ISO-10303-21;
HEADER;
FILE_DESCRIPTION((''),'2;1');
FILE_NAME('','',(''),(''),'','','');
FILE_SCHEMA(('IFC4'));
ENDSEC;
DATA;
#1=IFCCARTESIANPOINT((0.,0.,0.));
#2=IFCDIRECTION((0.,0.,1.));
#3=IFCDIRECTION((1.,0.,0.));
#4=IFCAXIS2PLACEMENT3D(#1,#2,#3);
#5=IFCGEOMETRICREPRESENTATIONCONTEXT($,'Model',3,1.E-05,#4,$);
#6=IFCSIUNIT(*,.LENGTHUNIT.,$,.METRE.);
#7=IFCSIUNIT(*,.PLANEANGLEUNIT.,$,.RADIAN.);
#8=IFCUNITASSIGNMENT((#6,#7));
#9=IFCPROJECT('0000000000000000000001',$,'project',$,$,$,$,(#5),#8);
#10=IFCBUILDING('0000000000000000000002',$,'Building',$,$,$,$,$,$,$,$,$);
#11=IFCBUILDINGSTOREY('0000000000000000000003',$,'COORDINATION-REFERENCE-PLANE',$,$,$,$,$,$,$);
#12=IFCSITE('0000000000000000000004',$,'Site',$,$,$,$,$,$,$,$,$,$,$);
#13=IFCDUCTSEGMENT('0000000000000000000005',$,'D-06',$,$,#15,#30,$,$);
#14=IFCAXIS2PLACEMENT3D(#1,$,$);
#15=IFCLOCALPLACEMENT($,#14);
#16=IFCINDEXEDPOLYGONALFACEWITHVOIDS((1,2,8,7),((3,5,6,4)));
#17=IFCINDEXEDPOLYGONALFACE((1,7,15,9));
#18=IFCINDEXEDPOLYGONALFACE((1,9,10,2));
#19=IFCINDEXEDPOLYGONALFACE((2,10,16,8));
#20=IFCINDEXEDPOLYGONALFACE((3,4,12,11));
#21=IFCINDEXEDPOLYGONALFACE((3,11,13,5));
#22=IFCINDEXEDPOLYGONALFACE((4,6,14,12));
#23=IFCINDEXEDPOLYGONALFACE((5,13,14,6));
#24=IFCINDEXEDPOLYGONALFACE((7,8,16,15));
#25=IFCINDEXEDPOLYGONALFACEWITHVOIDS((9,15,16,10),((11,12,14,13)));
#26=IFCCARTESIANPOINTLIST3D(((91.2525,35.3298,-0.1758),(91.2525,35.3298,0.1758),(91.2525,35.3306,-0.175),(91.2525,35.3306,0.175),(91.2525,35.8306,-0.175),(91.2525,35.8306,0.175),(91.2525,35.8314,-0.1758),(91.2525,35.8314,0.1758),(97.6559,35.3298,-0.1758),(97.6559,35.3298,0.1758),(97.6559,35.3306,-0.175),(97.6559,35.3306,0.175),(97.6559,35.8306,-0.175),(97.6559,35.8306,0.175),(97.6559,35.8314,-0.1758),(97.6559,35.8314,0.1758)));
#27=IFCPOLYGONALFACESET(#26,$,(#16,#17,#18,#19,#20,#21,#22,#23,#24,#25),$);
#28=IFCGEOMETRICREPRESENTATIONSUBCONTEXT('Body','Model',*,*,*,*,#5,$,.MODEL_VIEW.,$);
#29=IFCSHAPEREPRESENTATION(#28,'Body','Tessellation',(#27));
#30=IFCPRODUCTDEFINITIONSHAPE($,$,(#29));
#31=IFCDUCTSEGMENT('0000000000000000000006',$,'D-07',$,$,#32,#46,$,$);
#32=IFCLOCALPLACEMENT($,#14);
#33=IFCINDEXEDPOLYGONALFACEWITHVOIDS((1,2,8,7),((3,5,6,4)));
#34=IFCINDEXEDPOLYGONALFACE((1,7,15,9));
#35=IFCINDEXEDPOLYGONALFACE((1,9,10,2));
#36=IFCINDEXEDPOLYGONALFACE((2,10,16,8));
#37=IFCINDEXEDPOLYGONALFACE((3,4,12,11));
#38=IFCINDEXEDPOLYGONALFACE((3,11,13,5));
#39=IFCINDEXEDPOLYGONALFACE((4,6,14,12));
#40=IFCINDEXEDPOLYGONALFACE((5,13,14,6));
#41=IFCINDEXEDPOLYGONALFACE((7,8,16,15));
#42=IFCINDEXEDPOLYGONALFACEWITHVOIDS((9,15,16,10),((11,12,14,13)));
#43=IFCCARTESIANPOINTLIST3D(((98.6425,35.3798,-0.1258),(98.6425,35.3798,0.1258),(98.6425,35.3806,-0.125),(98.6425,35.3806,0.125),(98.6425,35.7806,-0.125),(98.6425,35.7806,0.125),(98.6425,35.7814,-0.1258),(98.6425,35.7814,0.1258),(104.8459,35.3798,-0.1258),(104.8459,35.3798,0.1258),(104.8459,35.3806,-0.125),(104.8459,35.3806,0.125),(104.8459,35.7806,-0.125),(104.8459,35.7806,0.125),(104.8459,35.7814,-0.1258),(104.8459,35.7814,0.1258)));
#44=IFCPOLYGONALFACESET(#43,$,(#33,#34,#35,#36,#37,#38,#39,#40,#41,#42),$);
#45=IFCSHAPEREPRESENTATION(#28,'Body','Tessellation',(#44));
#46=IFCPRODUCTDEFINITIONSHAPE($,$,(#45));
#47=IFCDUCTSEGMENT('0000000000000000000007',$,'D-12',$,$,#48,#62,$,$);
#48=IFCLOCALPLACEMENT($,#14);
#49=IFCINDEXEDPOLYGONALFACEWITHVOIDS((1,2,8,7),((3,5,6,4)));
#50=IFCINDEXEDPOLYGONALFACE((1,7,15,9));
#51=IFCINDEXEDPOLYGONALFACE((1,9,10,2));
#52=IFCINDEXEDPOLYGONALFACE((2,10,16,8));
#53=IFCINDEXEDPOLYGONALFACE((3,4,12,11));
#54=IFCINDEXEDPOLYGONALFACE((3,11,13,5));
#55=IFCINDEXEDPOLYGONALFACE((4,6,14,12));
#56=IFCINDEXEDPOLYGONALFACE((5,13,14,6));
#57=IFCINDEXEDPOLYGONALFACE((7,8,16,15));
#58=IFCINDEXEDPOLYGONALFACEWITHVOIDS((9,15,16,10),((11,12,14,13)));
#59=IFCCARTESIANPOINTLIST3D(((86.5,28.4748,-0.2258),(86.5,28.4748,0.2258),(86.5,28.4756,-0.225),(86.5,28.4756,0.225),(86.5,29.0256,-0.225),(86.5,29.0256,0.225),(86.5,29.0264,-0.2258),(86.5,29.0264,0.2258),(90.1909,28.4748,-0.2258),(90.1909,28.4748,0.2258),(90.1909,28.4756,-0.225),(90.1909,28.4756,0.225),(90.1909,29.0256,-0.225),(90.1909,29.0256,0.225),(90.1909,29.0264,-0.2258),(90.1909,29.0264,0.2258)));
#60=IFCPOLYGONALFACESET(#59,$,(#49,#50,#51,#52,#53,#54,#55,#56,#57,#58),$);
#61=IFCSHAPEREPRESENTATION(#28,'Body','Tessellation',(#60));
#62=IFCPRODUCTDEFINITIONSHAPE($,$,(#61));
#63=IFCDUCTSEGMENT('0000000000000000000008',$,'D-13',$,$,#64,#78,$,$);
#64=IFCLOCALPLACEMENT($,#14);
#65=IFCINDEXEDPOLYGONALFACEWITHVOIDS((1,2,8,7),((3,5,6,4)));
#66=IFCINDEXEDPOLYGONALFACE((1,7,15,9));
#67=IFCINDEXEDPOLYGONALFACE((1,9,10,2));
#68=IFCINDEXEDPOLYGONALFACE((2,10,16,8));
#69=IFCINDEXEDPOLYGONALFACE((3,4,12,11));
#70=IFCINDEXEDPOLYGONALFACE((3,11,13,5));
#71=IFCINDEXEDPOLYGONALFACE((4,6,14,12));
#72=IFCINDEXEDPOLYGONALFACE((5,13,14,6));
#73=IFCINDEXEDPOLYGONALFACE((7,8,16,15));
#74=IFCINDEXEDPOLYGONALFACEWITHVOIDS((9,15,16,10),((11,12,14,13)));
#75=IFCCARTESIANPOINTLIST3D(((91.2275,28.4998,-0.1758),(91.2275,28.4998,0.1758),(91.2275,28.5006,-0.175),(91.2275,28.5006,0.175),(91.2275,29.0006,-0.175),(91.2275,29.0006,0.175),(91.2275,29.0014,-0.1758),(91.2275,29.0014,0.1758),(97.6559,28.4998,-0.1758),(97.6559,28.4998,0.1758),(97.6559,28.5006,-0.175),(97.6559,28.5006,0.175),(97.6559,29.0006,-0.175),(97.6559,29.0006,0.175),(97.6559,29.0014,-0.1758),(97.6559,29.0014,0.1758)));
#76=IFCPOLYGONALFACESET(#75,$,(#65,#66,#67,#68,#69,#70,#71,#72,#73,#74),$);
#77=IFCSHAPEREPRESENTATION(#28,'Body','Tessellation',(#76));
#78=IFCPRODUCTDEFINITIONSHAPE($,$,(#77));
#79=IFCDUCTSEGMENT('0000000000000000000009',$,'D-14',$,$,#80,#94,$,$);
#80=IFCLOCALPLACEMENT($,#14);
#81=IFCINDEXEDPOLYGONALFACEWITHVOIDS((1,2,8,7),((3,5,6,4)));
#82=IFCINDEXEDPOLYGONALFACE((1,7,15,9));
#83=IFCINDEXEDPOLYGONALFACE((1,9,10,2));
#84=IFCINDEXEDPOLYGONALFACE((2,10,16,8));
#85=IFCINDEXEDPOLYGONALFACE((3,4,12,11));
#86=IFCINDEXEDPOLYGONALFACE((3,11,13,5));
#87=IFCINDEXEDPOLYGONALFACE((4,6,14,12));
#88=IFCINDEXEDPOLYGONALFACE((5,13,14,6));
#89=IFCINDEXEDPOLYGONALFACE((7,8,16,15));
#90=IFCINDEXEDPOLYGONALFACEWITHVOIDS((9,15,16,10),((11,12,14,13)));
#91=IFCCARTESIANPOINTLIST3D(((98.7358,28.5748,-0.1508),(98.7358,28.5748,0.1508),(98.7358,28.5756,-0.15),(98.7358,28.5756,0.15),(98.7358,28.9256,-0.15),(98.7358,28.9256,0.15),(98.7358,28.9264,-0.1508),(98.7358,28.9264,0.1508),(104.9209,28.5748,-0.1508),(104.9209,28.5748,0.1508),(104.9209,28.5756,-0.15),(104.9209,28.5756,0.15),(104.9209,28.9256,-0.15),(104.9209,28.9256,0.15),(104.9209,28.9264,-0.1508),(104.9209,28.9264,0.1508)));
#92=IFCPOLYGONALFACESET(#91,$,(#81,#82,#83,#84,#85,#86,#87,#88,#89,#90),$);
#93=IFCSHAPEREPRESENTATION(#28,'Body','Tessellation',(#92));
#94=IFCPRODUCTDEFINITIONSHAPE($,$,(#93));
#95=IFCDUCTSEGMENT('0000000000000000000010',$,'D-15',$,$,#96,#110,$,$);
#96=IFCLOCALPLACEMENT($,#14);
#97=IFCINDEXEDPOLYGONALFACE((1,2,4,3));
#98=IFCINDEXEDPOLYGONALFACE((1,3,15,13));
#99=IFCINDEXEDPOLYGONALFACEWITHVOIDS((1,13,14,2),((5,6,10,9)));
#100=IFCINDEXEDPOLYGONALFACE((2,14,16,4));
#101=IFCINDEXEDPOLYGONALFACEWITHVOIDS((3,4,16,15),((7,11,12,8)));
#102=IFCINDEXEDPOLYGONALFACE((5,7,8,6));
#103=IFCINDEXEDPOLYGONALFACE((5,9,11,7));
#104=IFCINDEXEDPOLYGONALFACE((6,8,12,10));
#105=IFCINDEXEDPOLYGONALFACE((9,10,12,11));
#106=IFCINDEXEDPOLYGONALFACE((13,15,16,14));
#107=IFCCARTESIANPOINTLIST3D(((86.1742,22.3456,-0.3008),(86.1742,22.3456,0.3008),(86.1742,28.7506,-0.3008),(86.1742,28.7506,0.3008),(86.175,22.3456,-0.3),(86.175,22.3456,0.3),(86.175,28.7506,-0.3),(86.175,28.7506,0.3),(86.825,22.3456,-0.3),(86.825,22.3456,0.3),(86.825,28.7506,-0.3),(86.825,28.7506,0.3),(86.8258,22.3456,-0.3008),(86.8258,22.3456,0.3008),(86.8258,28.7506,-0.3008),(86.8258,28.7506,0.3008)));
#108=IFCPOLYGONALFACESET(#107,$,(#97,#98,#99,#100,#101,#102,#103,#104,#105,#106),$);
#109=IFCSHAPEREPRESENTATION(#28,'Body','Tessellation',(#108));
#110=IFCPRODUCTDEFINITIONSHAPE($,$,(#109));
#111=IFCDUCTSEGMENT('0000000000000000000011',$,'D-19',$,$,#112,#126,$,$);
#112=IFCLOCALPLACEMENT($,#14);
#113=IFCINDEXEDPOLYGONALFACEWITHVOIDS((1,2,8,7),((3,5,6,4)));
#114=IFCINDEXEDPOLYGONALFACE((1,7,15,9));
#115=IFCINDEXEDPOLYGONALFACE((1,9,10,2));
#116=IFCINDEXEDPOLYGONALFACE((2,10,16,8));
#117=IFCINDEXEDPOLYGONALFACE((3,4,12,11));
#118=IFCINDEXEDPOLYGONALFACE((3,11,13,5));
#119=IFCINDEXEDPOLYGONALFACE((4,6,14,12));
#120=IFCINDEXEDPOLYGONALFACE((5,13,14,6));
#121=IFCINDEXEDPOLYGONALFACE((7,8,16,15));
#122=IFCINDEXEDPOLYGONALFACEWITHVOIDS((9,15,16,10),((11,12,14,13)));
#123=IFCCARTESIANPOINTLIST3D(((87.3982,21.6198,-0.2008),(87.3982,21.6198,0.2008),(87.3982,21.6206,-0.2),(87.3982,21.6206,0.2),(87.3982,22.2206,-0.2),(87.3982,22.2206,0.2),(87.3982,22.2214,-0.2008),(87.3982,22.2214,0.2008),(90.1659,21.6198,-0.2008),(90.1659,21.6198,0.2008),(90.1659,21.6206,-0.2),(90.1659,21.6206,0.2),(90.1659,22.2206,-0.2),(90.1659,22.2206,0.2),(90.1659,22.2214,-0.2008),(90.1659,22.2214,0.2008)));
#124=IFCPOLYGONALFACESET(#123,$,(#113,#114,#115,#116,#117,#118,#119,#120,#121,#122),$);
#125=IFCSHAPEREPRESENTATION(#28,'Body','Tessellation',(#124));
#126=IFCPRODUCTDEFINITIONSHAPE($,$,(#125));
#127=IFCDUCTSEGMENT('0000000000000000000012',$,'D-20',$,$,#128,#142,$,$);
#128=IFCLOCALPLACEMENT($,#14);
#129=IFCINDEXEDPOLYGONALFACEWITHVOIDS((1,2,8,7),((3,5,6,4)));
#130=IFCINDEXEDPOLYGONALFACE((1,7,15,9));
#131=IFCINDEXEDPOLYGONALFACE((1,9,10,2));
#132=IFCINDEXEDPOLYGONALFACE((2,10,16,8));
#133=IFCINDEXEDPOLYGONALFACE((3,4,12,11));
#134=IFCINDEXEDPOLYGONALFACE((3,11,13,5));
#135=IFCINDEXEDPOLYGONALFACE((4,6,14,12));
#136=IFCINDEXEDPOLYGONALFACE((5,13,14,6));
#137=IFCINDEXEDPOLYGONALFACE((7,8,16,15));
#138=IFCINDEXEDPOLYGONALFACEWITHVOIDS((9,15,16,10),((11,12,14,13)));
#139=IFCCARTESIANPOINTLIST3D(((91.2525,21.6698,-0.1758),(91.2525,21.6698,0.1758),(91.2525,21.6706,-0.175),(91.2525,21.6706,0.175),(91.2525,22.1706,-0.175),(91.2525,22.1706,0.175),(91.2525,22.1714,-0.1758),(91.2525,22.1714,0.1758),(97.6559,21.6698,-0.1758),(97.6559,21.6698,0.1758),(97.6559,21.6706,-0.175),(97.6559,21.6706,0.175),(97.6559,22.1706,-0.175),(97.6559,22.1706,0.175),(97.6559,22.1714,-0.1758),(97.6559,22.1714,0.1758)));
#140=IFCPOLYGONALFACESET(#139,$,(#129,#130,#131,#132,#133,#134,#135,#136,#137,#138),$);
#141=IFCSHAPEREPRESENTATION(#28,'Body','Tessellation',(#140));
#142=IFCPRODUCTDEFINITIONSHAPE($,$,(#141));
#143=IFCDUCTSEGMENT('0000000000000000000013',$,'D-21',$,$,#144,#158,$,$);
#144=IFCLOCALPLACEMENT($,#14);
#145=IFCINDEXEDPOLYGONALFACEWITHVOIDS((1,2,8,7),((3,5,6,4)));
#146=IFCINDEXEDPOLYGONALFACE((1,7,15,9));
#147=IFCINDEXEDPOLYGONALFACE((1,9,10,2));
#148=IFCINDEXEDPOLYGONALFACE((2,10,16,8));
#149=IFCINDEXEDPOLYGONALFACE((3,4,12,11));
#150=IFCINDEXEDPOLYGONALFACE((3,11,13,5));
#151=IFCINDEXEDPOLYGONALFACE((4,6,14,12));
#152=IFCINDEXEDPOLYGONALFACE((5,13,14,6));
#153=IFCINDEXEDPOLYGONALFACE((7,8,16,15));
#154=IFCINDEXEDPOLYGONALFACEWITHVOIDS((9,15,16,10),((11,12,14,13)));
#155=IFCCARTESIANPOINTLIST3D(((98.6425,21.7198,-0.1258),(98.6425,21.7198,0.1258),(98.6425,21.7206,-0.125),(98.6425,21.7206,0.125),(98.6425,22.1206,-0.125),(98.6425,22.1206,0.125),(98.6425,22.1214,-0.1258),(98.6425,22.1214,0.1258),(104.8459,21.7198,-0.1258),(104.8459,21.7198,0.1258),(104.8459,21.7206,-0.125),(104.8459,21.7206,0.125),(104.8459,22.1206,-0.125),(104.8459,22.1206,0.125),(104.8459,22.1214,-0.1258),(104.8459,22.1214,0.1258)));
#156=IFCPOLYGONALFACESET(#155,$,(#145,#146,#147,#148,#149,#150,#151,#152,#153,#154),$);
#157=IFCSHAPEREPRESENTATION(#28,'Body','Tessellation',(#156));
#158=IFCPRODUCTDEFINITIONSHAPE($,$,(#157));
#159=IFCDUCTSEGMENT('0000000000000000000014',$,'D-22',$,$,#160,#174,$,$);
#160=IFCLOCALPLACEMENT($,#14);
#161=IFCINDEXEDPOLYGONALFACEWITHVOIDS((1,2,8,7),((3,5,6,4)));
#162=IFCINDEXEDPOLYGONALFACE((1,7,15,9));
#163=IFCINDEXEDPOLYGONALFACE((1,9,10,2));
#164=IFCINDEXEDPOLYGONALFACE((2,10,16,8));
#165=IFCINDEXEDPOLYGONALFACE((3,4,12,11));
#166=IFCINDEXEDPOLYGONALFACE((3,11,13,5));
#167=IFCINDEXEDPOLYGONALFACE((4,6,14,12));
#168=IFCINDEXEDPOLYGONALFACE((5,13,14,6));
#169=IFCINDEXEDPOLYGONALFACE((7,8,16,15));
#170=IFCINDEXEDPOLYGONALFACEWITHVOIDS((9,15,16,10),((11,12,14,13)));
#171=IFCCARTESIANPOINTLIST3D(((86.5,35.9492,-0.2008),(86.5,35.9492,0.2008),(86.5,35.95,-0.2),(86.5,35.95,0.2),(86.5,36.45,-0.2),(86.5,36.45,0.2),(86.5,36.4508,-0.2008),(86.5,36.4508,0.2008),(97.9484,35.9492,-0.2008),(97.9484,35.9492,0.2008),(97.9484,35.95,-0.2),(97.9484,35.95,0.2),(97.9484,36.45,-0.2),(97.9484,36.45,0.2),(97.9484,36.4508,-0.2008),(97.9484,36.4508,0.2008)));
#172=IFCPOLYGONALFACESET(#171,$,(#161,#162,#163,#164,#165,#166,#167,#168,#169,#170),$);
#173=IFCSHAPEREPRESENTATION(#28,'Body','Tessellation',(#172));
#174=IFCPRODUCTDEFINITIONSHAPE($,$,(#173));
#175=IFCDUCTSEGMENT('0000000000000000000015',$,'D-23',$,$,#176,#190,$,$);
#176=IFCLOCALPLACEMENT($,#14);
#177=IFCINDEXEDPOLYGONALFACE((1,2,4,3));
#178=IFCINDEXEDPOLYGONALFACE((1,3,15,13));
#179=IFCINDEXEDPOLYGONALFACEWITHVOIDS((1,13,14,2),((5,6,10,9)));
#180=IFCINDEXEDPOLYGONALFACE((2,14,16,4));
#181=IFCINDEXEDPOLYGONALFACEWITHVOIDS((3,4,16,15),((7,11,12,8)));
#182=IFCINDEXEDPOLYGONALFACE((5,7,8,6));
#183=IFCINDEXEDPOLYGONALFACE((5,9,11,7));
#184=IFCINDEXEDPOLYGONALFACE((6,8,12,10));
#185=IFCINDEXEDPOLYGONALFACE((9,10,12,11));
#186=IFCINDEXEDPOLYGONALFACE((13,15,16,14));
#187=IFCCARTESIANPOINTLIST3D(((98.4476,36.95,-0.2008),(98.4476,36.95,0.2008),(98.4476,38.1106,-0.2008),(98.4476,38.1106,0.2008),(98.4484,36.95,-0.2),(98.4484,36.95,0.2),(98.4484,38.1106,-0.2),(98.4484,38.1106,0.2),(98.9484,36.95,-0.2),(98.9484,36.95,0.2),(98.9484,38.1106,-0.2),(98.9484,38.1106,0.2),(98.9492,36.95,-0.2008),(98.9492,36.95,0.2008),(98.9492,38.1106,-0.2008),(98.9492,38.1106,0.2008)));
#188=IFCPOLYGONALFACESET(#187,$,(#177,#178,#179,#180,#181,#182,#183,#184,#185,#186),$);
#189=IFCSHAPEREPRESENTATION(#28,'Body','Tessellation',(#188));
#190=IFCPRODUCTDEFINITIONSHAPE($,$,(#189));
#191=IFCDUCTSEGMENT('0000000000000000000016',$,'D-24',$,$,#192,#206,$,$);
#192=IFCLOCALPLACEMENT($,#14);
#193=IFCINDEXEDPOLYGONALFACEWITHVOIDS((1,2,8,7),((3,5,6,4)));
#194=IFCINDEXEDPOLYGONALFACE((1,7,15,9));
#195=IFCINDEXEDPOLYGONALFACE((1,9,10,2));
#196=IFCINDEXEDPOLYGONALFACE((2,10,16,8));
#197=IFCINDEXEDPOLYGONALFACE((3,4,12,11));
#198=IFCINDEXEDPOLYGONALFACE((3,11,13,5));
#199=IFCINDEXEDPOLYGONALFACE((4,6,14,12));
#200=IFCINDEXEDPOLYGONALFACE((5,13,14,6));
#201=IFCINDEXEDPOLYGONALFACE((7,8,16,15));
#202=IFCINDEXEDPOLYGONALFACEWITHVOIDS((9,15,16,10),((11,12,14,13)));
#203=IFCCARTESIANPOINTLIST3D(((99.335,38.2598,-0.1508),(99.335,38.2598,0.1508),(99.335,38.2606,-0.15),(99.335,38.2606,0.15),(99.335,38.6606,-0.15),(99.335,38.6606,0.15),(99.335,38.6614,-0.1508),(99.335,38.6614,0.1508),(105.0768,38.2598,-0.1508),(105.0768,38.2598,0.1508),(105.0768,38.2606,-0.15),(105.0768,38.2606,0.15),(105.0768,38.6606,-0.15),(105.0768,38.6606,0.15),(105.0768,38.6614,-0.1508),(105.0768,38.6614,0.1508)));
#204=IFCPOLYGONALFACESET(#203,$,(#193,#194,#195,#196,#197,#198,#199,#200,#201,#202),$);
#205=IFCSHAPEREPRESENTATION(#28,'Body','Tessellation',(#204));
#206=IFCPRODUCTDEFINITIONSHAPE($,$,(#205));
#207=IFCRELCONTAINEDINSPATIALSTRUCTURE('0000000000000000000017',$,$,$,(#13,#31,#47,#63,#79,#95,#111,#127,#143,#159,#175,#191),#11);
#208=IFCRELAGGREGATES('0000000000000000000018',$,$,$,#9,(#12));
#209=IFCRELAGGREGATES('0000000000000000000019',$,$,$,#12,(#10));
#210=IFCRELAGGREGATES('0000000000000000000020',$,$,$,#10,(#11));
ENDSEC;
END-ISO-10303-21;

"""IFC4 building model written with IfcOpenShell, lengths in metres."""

from ifc_helpers import new_model, si_unit, frame, origin, origin_with_axes, place, context, subcontext, project, spatial, hollow_rectangle, extrude, element, save


model = new_model("IFC4")

# Units and contexts
model_context = context("Model", 3, precision=1e-05, world=origin_with_axes())
body_context = subcontext(model_context, "Body", "Model", "MODEL_VIEW")
ifc_project = project(units=[si_unit("LENGTHUNIT", "METRE"), si_unit("PLANEANGLEUNIT", "RADIAN")], contexts=[model_context])

# Site, building, storey
site = spatial("IfcSite", under=ifc_project, Name="Site")
building = spatial("IfcBuilding", under=site, Name="Building")
storey = spatial("IfcBuildingStorey", under=building, Name="COORDINATION-REFERENCE-PLANE")

# Duct segments
duct_segment_1_placement = place(None, frame((91.2525, 35.5806, 0.0), z_axis=(1.0, 0.0, 0.0), x_axis=(0.0, 1.0, 0.0)))
element("IfcDuctSegment", 1, at=duct_segment_1_placement, inside=storey, Name="D-06", context=body_context, shape_type="SweptSolid", body=[
    extrude(hollow_rectangle(XDim=0.5016, YDim=0.3516, WallThickness=0.0008), origin(), (0.0, 0.0, 1.0), 6.4034),
])
duct_segment_2_placement = place(None, frame((98.6425, 35.5806, 0.0), z_axis=(1.0, 0.0, 0.0), x_axis=(0.0, 1.0, 0.0)))
element("IfcDuctSegment", 2, at=duct_segment_2_placement, inside=storey, Name="D-07", context=body_context, shape_type="SweptSolid", body=[
    extrude(hollow_rectangle(XDim=0.4016, YDim=0.2516, WallThickness=0.0008), origin(), (0.0, 0.0, 1.0), 6.2034),
])
duct_segment_3_placement = place(None, frame((86.5, 28.7506, 0.0), z_axis=(1.0, 0.0, 0.0), x_axis=(0.0, 1.0, 0.0)))
element("IfcDuctSegment", 3, at=duct_segment_3_placement, inside=storey, Name="D-12", context=body_context, shape_type="SweptSolid", body=[
    extrude(hollow_rectangle(XDim=0.5516, YDim=0.4516, WallThickness=0.0008), origin(), (0.0, 0.0, 1.0), 3.6909),
])
duct_segment_4_placement = place(None, frame((91.2275, 28.7506, 0.0), z_axis=(1.0, 0.0, 0.0), x_axis=(0.0, 1.0, 0.0)))
element("IfcDuctSegment", 4, at=duct_segment_4_placement, inside=storey, Name="D-13", context=body_context, shape_type="SweptSolid", body=[
    extrude(hollow_rectangle(XDim=0.5016, YDim=0.3516, WallThickness=0.0008), origin(), (0.0, 0.0, 1.0), 6.4284),
])
duct_segment_5_placement = place(None, frame((98.7358, 28.7506, 0.0), z_axis=(1.0, 0.0, 0.0), x_axis=(0.0, 1.0, 0.0)))
element("IfcDuctSegment", 5, at=duct_segment_5_placement, inside=storey, Name="D-14", context=body_context, shape_type="SweptSolid", body=[
    extrude(hollow_rectangle(XDim=0.3516, YDim=0.3016, WallThickness=0.0008), origin(), (0.0, 0.0, 1.0), 6.1851),
])
duct_segment_6_placement = place(None, frame((86.5, 22.3456, 0.0), z_axis=(0.0, 1.0, 0.0), x_axis=(1.0, 0.0, 0.0)))
element("IfcDuctSegment", 6, at=duct_segment_6_placement, inside=storey, Name="D-15", context=body_context, shape_type="SweptSolid", body=[
    extrude(hollow_rectangle(XDim=0.6516, YDim=0.6016, WallThickness=0.0008), origin(), (0.0, 0.0, 1.0), 6.405),
])
duct_segment_7_placement = place(None, frame((87.3982, 21.9206, 0.0), z_axis=(1.0, 0.0, 0.0), x_axis=(0.0, 1.0, 0.0)))
element("IfcDuctSegment", 7, at=duct_segment_7_placement, inside=storey, Name="D-19", context=body_context, shape_type="SweptSolid", body=[
    extrude(hollow_rectangle(XDim=0.6016, YDim=0.4016, WallThickness=0.0008), origin(), (0.0, 0.0, 1.0), 2.7677),
])
duct_segment_8_placement = place(None, frame((91.2525, 21.9206, 0.0), z_axis=(1.0, 0.0, 0.0), x_axis=(0.0, 1.0, 0.0)))
element("IfcDuctSegment", 8, at=duct_segment_8_placement, inside=storey, Name="D-20", context=body_context, shape_type="SweptSolid", body=[
    extrude(hollow_rectangle(XDim=0.5016, YDim=0.3516, WallThickness=0.0008), origin(), (0.0, 0.0, 1.0), 6.4034),
])
duct_segment_9_placement = place(None, frame((98.6425, 21.9206, 0.0), z_axis=(1.0, 0.0, 0.0), x_axis=(0.0, 1.0, 0.0)))
element("IfcDuctSegment", 9, at=duct_segment_9_placement, inside=storey, Name="D-21", context=body_context, shape_type="SweptSolid", body=[
    extrude(hollow_rectangle(XDim=0.4016, YDim=0.2516, WallThickness=0.0008), origin(), (0.0, 0.0, 1.0), 6.2034),
])
duct_segment_10_placement = place(None, frame((86.5, 36.2, 0.0), z_axis=(1.0, 0.0, 0.0), x_axis=(0.0, 1.0, 0.0)))
element("IfcDuctSegment", 10, at=duct_segment_10_placement, inside=storey, Name="D-22", context=body_context, shape_type="SweptSolid", body=[
    extrude(hollow_rectangle(XDim=0.5016, YDim=0.4016, WallThickness=0.0008), origin(), (0.0, 0.0, 1.0), 11.4484),
])
duct_segment_11_placement = place(None, frame((98.6984, 36.95, 0.0), z_axis=(0.0, 1.0, 0.0), x_axis=(1.0, 0.0, 0.0)))
element("IfcDuctSegment", 11, at=duct_segment_11_placement, inside=storey, Name="D-23", context=body_context, shape_type="SweptSolid", body=[
    extrude(hollow_rectangle(XDim=0.5016, YDim=0.4016, WallThickness=0.0008), origin(), (0.0, 0.0, 1.0), 1.1606),
])
duct_segment_12_placement = place(None, frame((99.335, 38.4606, 0.0), z_axis=(1.0, 0.0, 0.0), x_axis=(0.0, 1.0, 0.0)))
element("IfcDuctSegment", 12, at=duct_segment_12_placement, inside=storey, Name="D-24", context=body_context, shape_type="SweptSolid", body=[
    extrude(hollow_rectangle(XDim=0.4016, YDim=0.3016, WallThickness=0.0008), origin(), (0.0, 0.0, 1.0), 5.7417),
])

save(model, "model.ifc")
